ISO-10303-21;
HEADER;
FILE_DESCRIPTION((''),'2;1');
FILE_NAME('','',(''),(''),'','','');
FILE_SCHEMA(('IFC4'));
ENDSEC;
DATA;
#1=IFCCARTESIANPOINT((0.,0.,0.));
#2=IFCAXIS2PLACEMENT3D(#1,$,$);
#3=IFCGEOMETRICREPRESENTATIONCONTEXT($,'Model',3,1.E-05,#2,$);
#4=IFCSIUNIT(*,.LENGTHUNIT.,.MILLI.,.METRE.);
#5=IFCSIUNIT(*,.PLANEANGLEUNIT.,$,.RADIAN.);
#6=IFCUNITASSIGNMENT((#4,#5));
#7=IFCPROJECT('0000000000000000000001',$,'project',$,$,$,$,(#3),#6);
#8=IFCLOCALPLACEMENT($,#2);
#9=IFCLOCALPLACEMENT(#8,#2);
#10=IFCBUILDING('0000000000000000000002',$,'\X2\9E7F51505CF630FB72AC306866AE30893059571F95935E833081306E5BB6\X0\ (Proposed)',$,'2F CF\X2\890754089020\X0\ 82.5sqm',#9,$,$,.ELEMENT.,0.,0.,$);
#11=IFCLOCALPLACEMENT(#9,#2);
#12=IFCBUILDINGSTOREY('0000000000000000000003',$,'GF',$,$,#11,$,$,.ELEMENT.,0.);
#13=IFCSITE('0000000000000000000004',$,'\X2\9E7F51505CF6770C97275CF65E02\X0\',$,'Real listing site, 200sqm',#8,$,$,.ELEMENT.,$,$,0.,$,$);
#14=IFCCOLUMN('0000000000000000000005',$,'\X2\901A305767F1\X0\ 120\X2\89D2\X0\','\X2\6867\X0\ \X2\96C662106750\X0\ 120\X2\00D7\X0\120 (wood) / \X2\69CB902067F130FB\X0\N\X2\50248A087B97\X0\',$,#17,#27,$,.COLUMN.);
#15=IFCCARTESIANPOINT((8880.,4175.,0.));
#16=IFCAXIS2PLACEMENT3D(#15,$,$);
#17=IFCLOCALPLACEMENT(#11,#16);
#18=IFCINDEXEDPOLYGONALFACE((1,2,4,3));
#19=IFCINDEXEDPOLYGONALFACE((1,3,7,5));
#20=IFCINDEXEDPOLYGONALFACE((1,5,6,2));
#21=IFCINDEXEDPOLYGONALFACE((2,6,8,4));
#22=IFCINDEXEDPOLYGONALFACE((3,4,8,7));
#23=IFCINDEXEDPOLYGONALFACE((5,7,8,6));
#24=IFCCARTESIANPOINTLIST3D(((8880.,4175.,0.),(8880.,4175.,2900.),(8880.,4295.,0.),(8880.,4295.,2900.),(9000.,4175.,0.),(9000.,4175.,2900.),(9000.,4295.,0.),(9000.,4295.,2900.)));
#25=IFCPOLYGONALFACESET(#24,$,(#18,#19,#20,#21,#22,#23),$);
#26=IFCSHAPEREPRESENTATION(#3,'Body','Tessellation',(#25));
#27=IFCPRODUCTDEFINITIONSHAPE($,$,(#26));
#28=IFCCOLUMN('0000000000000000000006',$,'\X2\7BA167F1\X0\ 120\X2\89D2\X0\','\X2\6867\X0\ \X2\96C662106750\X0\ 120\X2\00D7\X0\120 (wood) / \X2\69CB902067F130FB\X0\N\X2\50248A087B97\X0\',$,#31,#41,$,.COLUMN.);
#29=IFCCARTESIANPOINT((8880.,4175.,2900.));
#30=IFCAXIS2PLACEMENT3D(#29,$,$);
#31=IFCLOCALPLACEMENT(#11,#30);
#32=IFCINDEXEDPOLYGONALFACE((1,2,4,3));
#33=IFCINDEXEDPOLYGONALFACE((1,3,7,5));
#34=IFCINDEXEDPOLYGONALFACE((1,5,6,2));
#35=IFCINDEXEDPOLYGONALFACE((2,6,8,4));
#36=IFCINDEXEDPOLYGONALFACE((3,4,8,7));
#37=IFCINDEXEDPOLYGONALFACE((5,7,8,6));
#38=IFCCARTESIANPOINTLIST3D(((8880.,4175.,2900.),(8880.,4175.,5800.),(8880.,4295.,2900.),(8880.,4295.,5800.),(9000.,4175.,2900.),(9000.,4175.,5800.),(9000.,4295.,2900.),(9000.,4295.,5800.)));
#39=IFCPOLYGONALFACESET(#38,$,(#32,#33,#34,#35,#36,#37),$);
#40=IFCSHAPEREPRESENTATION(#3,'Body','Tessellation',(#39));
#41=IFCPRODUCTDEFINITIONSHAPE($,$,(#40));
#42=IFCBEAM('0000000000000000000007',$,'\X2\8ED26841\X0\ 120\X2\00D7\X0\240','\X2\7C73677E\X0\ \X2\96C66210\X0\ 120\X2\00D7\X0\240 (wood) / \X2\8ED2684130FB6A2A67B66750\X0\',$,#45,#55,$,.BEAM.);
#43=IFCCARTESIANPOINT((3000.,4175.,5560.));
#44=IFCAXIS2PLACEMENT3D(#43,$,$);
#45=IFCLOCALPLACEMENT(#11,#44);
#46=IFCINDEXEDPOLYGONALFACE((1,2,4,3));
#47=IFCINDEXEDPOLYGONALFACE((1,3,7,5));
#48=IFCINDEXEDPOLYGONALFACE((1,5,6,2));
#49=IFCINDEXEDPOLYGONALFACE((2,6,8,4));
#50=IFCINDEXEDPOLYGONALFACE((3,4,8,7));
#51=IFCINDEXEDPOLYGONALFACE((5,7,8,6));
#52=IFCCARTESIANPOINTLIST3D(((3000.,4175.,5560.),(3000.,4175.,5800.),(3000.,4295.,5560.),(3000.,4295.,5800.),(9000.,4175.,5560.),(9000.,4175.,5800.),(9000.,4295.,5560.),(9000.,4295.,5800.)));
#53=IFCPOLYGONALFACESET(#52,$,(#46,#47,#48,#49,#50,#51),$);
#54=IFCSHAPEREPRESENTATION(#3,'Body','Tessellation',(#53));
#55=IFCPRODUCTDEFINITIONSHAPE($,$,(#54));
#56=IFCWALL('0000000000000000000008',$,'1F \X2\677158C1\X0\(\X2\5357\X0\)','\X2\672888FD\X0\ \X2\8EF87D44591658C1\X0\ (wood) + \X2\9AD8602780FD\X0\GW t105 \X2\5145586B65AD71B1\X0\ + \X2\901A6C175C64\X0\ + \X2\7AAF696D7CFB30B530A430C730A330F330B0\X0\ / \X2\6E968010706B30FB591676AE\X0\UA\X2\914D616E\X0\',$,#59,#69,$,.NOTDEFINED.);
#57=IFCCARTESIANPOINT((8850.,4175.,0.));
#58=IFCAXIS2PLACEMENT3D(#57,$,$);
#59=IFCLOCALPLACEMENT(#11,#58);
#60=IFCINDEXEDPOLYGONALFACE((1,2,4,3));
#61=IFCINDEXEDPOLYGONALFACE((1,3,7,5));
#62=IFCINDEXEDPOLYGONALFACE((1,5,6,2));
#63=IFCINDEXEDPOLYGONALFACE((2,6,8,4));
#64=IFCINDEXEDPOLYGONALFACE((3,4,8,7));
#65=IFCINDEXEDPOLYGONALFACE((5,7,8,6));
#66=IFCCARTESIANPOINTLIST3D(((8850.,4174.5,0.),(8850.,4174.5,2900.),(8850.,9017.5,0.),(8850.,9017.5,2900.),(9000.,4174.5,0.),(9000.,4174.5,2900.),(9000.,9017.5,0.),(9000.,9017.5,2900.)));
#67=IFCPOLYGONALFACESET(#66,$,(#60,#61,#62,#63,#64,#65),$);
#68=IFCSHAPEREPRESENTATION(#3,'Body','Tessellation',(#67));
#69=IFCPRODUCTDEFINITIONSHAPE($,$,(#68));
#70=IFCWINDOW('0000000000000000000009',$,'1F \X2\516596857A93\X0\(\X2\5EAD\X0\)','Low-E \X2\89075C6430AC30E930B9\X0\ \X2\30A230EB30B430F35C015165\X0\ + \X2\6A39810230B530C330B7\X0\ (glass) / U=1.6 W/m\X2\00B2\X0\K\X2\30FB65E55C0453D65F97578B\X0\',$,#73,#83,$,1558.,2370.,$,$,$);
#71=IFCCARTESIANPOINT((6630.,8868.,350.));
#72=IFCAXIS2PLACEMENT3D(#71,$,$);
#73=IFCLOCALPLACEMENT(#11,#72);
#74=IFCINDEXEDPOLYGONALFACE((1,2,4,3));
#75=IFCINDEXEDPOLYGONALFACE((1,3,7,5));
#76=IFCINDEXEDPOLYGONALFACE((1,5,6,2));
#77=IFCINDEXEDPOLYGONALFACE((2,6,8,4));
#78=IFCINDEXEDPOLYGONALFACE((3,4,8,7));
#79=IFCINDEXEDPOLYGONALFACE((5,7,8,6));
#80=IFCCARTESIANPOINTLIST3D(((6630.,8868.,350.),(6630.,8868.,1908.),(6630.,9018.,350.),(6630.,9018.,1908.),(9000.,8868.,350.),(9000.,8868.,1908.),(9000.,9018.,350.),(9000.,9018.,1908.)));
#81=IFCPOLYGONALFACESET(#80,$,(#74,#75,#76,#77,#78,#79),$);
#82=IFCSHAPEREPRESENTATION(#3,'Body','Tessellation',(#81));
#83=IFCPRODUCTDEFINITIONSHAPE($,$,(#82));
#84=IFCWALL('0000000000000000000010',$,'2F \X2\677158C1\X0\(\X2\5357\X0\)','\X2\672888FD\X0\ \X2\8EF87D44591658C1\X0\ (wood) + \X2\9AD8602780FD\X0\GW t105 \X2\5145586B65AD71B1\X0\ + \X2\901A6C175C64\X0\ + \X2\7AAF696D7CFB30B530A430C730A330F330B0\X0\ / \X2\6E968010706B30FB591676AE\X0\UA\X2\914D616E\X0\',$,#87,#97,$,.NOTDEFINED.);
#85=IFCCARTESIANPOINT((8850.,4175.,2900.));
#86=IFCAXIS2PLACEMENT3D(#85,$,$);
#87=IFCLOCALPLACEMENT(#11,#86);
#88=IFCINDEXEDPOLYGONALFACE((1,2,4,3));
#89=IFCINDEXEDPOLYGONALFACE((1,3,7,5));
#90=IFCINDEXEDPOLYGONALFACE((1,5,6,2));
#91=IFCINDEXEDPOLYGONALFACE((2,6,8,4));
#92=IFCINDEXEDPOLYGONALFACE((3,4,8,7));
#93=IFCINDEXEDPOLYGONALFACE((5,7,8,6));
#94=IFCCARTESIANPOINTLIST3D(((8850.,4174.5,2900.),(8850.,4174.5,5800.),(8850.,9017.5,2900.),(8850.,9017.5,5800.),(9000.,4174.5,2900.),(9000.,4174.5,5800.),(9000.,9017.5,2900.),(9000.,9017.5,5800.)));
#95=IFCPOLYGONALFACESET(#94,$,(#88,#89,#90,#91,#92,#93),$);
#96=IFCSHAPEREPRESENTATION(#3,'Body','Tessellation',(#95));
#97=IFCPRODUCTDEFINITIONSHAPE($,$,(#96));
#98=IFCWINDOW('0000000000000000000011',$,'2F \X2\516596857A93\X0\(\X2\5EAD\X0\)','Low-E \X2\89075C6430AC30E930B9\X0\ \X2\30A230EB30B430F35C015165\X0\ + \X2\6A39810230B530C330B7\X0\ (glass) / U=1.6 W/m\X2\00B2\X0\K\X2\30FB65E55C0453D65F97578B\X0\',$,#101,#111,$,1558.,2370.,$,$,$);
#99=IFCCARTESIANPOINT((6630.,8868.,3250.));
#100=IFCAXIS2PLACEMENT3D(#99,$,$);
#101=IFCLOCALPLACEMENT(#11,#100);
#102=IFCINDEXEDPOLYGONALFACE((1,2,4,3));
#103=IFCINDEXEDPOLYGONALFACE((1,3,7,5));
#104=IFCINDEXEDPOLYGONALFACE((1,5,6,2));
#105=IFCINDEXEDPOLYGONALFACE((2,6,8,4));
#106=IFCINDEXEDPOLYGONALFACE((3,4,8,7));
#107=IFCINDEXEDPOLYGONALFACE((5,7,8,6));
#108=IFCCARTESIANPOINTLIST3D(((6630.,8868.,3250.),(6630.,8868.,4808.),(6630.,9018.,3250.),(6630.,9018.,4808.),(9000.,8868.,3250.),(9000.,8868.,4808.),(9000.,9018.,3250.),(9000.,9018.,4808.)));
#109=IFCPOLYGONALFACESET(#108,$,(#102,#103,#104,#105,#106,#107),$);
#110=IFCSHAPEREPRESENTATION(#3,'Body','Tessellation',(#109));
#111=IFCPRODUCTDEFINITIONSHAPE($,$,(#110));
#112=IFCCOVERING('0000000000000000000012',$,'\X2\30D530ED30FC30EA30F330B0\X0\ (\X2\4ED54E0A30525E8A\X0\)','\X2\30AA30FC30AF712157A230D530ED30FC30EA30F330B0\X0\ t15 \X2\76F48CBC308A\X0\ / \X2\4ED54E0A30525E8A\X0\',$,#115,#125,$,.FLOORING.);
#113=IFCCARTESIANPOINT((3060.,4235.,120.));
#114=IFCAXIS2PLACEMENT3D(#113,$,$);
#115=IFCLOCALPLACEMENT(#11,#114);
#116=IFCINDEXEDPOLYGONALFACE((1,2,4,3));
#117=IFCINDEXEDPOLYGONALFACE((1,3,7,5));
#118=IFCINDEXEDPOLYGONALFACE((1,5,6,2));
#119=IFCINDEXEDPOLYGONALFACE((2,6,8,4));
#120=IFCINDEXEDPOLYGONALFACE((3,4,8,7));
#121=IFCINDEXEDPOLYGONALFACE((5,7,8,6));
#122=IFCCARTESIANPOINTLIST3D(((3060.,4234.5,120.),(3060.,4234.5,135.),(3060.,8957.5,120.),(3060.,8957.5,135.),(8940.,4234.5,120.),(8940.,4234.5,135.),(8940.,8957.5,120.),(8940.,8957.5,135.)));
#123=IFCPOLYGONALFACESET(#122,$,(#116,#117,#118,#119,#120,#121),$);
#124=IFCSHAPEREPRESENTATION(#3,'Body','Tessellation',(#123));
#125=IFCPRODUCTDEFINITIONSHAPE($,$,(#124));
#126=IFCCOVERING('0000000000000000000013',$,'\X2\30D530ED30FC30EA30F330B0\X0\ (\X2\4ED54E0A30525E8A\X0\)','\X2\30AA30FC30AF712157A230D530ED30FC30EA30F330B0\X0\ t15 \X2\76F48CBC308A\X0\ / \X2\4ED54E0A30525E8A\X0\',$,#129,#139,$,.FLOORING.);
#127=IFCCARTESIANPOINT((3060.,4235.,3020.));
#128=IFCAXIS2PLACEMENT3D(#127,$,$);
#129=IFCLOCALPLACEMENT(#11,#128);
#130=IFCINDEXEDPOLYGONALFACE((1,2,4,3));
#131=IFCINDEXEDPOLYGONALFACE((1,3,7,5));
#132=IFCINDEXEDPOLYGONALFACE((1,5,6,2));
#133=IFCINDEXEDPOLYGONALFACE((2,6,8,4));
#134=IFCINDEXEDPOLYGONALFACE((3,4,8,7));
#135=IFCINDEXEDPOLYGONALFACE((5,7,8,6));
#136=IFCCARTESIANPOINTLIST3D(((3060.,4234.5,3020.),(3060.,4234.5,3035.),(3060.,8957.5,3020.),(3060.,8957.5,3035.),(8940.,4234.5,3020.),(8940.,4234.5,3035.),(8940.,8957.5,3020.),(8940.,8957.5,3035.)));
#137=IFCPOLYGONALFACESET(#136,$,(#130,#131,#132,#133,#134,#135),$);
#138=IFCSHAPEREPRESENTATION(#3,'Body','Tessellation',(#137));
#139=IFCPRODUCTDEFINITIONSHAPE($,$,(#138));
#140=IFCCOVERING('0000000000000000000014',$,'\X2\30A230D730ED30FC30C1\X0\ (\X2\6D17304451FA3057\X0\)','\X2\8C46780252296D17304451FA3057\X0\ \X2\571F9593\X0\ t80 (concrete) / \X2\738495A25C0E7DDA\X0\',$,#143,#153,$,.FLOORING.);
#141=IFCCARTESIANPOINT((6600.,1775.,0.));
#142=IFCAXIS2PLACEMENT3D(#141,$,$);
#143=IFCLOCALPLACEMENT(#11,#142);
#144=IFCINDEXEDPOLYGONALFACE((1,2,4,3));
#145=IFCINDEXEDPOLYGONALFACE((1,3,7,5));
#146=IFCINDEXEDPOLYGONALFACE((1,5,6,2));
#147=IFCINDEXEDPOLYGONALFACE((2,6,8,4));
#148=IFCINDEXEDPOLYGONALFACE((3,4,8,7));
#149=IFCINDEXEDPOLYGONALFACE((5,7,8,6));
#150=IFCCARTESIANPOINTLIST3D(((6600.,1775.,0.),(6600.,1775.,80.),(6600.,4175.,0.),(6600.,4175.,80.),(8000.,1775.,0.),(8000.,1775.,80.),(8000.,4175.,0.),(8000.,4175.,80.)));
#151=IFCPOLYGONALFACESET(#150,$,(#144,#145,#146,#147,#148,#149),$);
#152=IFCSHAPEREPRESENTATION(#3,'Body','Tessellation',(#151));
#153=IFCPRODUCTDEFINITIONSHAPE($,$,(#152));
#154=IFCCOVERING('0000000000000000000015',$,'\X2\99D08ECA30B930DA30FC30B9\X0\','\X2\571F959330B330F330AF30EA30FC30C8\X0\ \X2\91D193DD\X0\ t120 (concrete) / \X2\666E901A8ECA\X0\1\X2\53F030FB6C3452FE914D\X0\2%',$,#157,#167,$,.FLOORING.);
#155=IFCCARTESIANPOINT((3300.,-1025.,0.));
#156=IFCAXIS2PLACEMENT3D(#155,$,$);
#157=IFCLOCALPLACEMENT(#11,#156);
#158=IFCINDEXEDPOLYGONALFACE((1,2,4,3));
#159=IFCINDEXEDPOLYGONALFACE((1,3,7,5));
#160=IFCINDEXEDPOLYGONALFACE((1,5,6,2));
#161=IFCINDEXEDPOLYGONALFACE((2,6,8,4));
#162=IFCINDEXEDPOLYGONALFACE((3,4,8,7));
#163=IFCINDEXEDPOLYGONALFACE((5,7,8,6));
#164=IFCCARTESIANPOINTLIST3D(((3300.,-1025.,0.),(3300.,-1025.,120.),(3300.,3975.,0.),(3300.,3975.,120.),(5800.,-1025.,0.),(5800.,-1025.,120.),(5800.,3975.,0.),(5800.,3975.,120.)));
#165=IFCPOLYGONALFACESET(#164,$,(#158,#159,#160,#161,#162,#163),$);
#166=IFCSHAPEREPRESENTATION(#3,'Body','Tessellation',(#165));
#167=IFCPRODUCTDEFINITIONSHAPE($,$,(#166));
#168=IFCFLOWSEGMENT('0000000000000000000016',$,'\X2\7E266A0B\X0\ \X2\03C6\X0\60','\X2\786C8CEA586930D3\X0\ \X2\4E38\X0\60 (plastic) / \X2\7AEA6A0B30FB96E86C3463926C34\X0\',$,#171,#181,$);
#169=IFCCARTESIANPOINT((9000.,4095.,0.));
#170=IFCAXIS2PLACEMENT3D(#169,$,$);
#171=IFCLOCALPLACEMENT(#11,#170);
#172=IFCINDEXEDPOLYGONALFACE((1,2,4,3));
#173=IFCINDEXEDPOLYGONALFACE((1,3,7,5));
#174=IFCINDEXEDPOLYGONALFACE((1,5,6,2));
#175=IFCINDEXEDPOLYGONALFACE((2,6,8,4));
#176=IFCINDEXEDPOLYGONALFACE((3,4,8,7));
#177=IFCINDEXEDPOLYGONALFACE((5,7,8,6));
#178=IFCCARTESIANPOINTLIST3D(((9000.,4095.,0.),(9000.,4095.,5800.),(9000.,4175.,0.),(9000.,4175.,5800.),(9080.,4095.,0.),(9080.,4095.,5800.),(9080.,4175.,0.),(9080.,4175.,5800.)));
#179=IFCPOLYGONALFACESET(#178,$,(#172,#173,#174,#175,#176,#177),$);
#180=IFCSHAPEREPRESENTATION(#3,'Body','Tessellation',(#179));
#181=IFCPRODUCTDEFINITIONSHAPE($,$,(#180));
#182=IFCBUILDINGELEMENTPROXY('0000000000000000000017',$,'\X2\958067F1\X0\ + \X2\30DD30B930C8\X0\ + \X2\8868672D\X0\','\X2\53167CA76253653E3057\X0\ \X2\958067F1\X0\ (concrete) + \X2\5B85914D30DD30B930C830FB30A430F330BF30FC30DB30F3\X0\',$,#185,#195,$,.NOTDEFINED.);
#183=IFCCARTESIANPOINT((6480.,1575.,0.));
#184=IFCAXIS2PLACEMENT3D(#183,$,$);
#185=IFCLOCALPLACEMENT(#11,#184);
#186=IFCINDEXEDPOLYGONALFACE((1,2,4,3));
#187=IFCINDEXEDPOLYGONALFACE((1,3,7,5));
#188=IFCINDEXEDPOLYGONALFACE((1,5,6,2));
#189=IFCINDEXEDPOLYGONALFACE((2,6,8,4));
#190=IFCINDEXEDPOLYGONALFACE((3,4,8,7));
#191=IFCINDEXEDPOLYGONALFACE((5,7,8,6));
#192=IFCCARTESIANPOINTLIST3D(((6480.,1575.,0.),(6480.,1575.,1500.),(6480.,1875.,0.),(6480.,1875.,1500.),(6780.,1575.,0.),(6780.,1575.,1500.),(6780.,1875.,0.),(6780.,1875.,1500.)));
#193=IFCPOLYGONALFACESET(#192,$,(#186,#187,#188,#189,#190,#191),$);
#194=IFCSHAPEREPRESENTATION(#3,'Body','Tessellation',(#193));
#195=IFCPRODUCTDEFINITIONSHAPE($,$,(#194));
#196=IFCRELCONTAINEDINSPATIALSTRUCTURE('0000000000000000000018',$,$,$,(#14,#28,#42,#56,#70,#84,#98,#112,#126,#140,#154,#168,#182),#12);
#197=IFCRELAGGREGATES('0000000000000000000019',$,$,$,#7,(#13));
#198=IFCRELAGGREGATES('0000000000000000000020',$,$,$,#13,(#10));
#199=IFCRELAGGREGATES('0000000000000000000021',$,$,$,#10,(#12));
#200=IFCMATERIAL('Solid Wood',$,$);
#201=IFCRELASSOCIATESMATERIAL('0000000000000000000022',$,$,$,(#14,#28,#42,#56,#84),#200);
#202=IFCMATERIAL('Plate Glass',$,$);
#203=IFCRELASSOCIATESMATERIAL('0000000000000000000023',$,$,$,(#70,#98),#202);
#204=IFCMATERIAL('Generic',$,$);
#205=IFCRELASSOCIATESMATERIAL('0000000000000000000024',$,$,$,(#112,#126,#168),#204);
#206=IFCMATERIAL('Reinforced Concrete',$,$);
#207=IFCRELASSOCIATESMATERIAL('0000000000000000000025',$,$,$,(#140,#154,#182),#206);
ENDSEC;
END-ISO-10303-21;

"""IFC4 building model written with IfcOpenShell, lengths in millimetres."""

from ifc_helpers import new_model, si_unit, frame, frame_2d, origin, place, context, project, spatial, rectangle, extrude, material, element, fill, save


model = new_model("IFC4")

# Units and contexts
model_context = context("Model", 3, precision=1e-05, world=origin())
ifc_project = project(units=[si_unit("LENGTHUNIT", "METRE", prefix="MILLI"), si_unit("PLANEANGLEUNIT", "RADIAN")], contexts=[model_context])

# Site, building, storey
site_placement = place(None, origin())
site = spatial("IfcSite", under=ifc_project, at=site_placement, Name="鹿児島県霧島市", ObjectType="Real listing site, 200sqm", CompositionType="ELEMENT", RefElevation=0.0)
building_placement = place(site_placement, origin())
building = spatial("IfcBuilding", under=site, at=building_placement, Name="鹿児島・犬と暮らす土間広めの家 (Proposed)", ObjectType="2F CF複合造 82.5sqm", CompositionType="ELEMENT", ElevationOfRefHeight=0.0, ElevationOfTerrain=0.0)
storey_placement = place(building_placement, origin())
storey = spatial("IfcBuildingStorey", under=building, at=storey_placement, Name="GF", CompositionType="ELEMENT", Elevation=0.0)

# Columns
ifc_material_1 = material(Name="Solid Wood")
column_1_placement = place(storey_placement, frame((8880.0, 4175.0, 0.0)))
element("IfcColumn", 1, at=column_1_placement, inside=storey, material=ifc_material_1, Name="通し柱 120角", Description="桧 集成材 120×120 (wood) / 構造柱・N値計算", PredefinedType="COLUMN", context=model_context, shape_type="SweptSolid", body=[
    extrude(rectangle(XDim=120.0, YDim=120.0, at=frame_2d((60.0, 60.0))), frame((8880.0, 4175.0, 0.0)), (0.0, 0.0, 1.0), 2900.0),
])
column_2_placement = place(storey_placement, frame((8880.0, 4175.0, 2900.0)))
element("IfcColumn", 2, at=column_2_placement, inside=storey, material=ifc_material_1, Name="管柱 120角", Description="桧 集成材 120×120 (wood) / 構造柱・N値計算", PredefinedType="COLUMN", context=model_context, shape_type="SweptSolid", body=[
    extrude(rectangle(XDim=120.0, YDim=120.0, at=frame_2d((60.0, 60.0))), frame((8880.0, 4175.0, 2900.0)), (0.0, 0.0, 1.0), 2900.0),
])

# Beam
beam_1_placement = place(storey_placement, frame((3000.0, 4175.0, 5560.0)))
element("IfcBeam", 3, at=beam_1_placement, inside=storey, material=ifc_material_1, Name="軒桁 120×240", Description="米松 集成 120×240 (wood) / 軒桁・横架材", PredefinedType="BEAM", context=model_context, shape_type="SweptSolid", body=[
    extrude(rectangle(XDim=6000.0, YDim=120.0, at=frame_2d((3000.0, 60.0))), frame((3000.0, 4175.0, 5560.0)), (0.0, 0.0, 1.0), 240.0),
])

# Wall, opening, window
wall_1_placement = place(storey_placement, frame((8850.0, 4175.0, 0.0)))
wall_1 = element("IfcWall", 4, at=wall_1_placement, inside=storey, material=ifc_material_1, Name="1F 東壁(南)", Description="木製 軸組外壁 (wood) + 高性能GW t105 充填断熱 + 通気層 + 窯業系サイディング / 準耐火・外皮UA配慮", PredefinedType="NOTDEFINED", context=model_context, shape_type="SweptSolid", body=[
    extrude(rectangle(XDim=150.0, YDim=4843.0, at=frame_2d((75.0, 2421.0))), frame((8850.0, 4175.0, 0.0)), (0.0, 0.0, 1.0), 2900.0),
])
opening_1_placement = place(storey_placement, frame((6630.0, 8868.0, 350.0)))
opening_1 = element("IfcOpeningElement", 5, at=opening_1_placement, cuts=wall_1, PredefinedType="NOTDEFINED", context=model_context, shape_type="SweptSolid", body=[
    extrude(rectangle(XDim=2370.0, YDim=150.0, at=frame_2d((1185.0, 75.0))), frame((6630.0, 8868.0, 350.0)), (0.0, 0.0, 1.0), 1558.0),
])
ifc_material_2 = material(Name="Plate Glass")
window_1_placement = place(storey_placement, frame((6630.0, 8868.0, 350.0)))
window_1 = element("IfcWindow", 6, at=window_1_placement, inside=storey, material=ifc_material_2, Name="1F 入隅窓(庭)", Description="Low-E 複層ガラス アルゴン封入 + 樹脂サッシ (glass) / U=1.6 W/m²K・日射取得型", OverallHeight=1558.0, OverallWidth=2370.0, context=model_context, shape_type="SweptSolid", body=[
    extrude(rectangle(XDim=2370.0, YDim=150.0, at=frame_2d((1185.0, 75.0))), frame((6630.0, 8868.0, 350.0)), (0.0, 0.0, 1.0), 1558.0),
])
fill(opening_1, window_1)

# Wall, opening, window
wall_2_placement = place(storey_placement, frame((8850.0, 4175.0, 2900.0)))
wall_2 = element("IfcWall", 7, at=wall_2_placement, inside=storey, material=ifc_material_1, Name="2F 東壁(南)", Description="木製 軸組外壁 (wood) + 高性能GW t105 充填断熱 + 通気層 + 窯業系サイディング / 準耐火・外皮UA配慮", PredefinedType="NOTDEFINED", context=model_context, shape_type="SweptSolid", body=[
    extrude(rectangle(XDim=150.0, YDim=4843.0, at=frame_2d((75.0, 2421.0))), frame((8850.0, 4175.0, 2900.0)), (0.0, 0.0, 1.0), 2900.0),
])
opening_2_placement = place(storey_placement, frame((6630.0, 8868.0, 3250.0)))
opening_2 = element("IfcOpeningElement", 8, at=opening_2_placement, cuts=wall_2, PredefinedType="NOTDEFINED", context=model_context, shape_type="SweptSolid", body=[
    extrude(rectangle(XDim=2370.0, YDim=150.0, at=frame_2d((1185.0, 75.0))), frame((6630.0, 8868.0, 3250.0)), (0.0, 0.0, 1.0), 1558.0),
])
window_2_placement = place(storey_placement, frame((6630.0, 8868.0, 3250.0)))
window_2 = element("IfcWindow", 9, at=window_2_placement, inside=storey, material=ifc_material_2, Name="2F 入隅窓(庭)", Description="Low-E 複層ガラス アルゴン封入 + 樹脂サッシ (glass) / U=1.6 W/m²K・日射取得型", OverallHeight=1558.0, OverallWidth=2370.0, context=model_context, shape_type="SweptSolid", body=[
    extrude(rectangle(XDim=2370.0, YDim=150.0, at=frame_2d((1185.0, 75.0))), frame((6630.0, 8868.0, 3250.0)), (0.0, 0.0, 1.0), 1558.0),
])
fill(opening_2, window_2)

# Coverings
ifc_material_3 = material(Name="Generic")
covering_1_placement = place(storey_placement, frame((3060.0, 4235.0, 120.0)))
element("IfcCovering", 10, at=covering_1_placement, inside=storey, material=ifc_material_3, Name="フローリング (仕上げ床)", Description="オーク無垢フローリング t15 直貼り / 仕上げ床", PredefinedType="FLOORING", context=model_context, shape_type="SweptSolid", body=[
    extrude(rectangle(XDim=5880.0, YDim=4723.0, at=frame_2d((2940.0, 2361.0))), frame((3060.0, 4235.0, 120.0)), (0.0, 0.0, 1.0), 15.0),
])
covering_2_placement = place(storey_placement, frame((3060.0, 4235.0, 3020.0)))
element("IfcCovering", 11, at=covering_2_placement, inside=storey, material=ifc_material_3, Name="フローリング (仕上げ床)", Description="オーク無垢フローリング t15 直貼り / 仕上げ床", PredefinedType="FLOORING", context=model_context, shape_type="SweptSolid", body=[
    extrude(rectangle(XDim=5880.0, YDim=4723.0, at=frame_2d((2940.0, 2361.0))), frame((3060.0, 4235.0, 3020.0)), (0.0, 0.0, 1.0), 15.0),
])
ifc_material_4 = material(Name="Reinforced Concrete")
covering_3_placement = place(storey_placement, frame((6600.0, 1775.0, 0.0)))
element("IfcCovering", 12, at=covering_3_placement, inside=storey, material=ifc_material_4, Name="アプローチ (洗い出し)", Description="豆砂利洗い出し 土間 t80 (concrete) / 玄関導線", PredefinedType="FLOORING", context=model_context, shape_type="SweptSolid", body=[
    extrude(rectangle(XDim=1400.0, YDim=2400.0, at=frame_2d((700.0, 1200.0))), frame((6600.0, 1775.0, 0.0)), (0.0, 0.0, 1.0), 80.0),
])
covering_4_placement = place(storey_placement, frame((3300.0, -1025.0, 0.0)))
element("IfcCovering", 13, at=covering_4_placement, inside=storey, material=ifc_material_4, Name="駐車スペース", Description="土間コンクリート 金鏝 t120 (concrete) / 普通車1台・水勾配2%", PredefinedType="FLOORING", context=model_context, shape_type="SweptSolid", body=[
    extrude(rectangle(XDim=2500.0, YDim=5000.0, at=frame_2d((1250.0, 2500.0))), frame((3300.0, -1025.0, 0.0)), (0.0, 0.0, 1.0), 120.0),
])

# Flow segment
flow_segment_placement = place(storey_placement, frame((9000.0, 4095.0, 0.0)))
element("IfcFlowSegment", 14, at=flow_segment_placement, inside=storey, material=ifc_material_3, Name="縦樋 φ60", Description="硬質塩ビ 丸60 (plastic) / 竪樋・雨水排水", context=model_context, shape_type="SweptSolid", body=[
    extrude(rectangle(XDim=80.0, YDim=80.0, at=frame_2d((40.0, 40.0))), frame((9000.0, 4095.0, 0.0)), (0.0, 0.0, 1.0), 5800.0),
])

# Building element proxy
proxy_placement = place(storey_placement, frame((6480.0, 1575.0, 0.0)))
element("IfcBuildingElementProxy", 15, at=proxy_placement, inside=storey, material=ifc_material_4, Name="門柱 + ポスト + 表札", Description="化粧打放し 門柱 (concrete) + 宅配ポスト・インターホン", PredefinedType="NOTDEFINED", context=model_context, shape_type="SweptSolid", body=[
    extrude(rectangle(XDim=300.0, YDim=300.0, at=frame_2d((150.0, 150.0))), frame((6480.0, 1575.0, 0.0)), (0.0, 0.0, 1.0), 1500.0),
])

save(model, "model.ifc")
